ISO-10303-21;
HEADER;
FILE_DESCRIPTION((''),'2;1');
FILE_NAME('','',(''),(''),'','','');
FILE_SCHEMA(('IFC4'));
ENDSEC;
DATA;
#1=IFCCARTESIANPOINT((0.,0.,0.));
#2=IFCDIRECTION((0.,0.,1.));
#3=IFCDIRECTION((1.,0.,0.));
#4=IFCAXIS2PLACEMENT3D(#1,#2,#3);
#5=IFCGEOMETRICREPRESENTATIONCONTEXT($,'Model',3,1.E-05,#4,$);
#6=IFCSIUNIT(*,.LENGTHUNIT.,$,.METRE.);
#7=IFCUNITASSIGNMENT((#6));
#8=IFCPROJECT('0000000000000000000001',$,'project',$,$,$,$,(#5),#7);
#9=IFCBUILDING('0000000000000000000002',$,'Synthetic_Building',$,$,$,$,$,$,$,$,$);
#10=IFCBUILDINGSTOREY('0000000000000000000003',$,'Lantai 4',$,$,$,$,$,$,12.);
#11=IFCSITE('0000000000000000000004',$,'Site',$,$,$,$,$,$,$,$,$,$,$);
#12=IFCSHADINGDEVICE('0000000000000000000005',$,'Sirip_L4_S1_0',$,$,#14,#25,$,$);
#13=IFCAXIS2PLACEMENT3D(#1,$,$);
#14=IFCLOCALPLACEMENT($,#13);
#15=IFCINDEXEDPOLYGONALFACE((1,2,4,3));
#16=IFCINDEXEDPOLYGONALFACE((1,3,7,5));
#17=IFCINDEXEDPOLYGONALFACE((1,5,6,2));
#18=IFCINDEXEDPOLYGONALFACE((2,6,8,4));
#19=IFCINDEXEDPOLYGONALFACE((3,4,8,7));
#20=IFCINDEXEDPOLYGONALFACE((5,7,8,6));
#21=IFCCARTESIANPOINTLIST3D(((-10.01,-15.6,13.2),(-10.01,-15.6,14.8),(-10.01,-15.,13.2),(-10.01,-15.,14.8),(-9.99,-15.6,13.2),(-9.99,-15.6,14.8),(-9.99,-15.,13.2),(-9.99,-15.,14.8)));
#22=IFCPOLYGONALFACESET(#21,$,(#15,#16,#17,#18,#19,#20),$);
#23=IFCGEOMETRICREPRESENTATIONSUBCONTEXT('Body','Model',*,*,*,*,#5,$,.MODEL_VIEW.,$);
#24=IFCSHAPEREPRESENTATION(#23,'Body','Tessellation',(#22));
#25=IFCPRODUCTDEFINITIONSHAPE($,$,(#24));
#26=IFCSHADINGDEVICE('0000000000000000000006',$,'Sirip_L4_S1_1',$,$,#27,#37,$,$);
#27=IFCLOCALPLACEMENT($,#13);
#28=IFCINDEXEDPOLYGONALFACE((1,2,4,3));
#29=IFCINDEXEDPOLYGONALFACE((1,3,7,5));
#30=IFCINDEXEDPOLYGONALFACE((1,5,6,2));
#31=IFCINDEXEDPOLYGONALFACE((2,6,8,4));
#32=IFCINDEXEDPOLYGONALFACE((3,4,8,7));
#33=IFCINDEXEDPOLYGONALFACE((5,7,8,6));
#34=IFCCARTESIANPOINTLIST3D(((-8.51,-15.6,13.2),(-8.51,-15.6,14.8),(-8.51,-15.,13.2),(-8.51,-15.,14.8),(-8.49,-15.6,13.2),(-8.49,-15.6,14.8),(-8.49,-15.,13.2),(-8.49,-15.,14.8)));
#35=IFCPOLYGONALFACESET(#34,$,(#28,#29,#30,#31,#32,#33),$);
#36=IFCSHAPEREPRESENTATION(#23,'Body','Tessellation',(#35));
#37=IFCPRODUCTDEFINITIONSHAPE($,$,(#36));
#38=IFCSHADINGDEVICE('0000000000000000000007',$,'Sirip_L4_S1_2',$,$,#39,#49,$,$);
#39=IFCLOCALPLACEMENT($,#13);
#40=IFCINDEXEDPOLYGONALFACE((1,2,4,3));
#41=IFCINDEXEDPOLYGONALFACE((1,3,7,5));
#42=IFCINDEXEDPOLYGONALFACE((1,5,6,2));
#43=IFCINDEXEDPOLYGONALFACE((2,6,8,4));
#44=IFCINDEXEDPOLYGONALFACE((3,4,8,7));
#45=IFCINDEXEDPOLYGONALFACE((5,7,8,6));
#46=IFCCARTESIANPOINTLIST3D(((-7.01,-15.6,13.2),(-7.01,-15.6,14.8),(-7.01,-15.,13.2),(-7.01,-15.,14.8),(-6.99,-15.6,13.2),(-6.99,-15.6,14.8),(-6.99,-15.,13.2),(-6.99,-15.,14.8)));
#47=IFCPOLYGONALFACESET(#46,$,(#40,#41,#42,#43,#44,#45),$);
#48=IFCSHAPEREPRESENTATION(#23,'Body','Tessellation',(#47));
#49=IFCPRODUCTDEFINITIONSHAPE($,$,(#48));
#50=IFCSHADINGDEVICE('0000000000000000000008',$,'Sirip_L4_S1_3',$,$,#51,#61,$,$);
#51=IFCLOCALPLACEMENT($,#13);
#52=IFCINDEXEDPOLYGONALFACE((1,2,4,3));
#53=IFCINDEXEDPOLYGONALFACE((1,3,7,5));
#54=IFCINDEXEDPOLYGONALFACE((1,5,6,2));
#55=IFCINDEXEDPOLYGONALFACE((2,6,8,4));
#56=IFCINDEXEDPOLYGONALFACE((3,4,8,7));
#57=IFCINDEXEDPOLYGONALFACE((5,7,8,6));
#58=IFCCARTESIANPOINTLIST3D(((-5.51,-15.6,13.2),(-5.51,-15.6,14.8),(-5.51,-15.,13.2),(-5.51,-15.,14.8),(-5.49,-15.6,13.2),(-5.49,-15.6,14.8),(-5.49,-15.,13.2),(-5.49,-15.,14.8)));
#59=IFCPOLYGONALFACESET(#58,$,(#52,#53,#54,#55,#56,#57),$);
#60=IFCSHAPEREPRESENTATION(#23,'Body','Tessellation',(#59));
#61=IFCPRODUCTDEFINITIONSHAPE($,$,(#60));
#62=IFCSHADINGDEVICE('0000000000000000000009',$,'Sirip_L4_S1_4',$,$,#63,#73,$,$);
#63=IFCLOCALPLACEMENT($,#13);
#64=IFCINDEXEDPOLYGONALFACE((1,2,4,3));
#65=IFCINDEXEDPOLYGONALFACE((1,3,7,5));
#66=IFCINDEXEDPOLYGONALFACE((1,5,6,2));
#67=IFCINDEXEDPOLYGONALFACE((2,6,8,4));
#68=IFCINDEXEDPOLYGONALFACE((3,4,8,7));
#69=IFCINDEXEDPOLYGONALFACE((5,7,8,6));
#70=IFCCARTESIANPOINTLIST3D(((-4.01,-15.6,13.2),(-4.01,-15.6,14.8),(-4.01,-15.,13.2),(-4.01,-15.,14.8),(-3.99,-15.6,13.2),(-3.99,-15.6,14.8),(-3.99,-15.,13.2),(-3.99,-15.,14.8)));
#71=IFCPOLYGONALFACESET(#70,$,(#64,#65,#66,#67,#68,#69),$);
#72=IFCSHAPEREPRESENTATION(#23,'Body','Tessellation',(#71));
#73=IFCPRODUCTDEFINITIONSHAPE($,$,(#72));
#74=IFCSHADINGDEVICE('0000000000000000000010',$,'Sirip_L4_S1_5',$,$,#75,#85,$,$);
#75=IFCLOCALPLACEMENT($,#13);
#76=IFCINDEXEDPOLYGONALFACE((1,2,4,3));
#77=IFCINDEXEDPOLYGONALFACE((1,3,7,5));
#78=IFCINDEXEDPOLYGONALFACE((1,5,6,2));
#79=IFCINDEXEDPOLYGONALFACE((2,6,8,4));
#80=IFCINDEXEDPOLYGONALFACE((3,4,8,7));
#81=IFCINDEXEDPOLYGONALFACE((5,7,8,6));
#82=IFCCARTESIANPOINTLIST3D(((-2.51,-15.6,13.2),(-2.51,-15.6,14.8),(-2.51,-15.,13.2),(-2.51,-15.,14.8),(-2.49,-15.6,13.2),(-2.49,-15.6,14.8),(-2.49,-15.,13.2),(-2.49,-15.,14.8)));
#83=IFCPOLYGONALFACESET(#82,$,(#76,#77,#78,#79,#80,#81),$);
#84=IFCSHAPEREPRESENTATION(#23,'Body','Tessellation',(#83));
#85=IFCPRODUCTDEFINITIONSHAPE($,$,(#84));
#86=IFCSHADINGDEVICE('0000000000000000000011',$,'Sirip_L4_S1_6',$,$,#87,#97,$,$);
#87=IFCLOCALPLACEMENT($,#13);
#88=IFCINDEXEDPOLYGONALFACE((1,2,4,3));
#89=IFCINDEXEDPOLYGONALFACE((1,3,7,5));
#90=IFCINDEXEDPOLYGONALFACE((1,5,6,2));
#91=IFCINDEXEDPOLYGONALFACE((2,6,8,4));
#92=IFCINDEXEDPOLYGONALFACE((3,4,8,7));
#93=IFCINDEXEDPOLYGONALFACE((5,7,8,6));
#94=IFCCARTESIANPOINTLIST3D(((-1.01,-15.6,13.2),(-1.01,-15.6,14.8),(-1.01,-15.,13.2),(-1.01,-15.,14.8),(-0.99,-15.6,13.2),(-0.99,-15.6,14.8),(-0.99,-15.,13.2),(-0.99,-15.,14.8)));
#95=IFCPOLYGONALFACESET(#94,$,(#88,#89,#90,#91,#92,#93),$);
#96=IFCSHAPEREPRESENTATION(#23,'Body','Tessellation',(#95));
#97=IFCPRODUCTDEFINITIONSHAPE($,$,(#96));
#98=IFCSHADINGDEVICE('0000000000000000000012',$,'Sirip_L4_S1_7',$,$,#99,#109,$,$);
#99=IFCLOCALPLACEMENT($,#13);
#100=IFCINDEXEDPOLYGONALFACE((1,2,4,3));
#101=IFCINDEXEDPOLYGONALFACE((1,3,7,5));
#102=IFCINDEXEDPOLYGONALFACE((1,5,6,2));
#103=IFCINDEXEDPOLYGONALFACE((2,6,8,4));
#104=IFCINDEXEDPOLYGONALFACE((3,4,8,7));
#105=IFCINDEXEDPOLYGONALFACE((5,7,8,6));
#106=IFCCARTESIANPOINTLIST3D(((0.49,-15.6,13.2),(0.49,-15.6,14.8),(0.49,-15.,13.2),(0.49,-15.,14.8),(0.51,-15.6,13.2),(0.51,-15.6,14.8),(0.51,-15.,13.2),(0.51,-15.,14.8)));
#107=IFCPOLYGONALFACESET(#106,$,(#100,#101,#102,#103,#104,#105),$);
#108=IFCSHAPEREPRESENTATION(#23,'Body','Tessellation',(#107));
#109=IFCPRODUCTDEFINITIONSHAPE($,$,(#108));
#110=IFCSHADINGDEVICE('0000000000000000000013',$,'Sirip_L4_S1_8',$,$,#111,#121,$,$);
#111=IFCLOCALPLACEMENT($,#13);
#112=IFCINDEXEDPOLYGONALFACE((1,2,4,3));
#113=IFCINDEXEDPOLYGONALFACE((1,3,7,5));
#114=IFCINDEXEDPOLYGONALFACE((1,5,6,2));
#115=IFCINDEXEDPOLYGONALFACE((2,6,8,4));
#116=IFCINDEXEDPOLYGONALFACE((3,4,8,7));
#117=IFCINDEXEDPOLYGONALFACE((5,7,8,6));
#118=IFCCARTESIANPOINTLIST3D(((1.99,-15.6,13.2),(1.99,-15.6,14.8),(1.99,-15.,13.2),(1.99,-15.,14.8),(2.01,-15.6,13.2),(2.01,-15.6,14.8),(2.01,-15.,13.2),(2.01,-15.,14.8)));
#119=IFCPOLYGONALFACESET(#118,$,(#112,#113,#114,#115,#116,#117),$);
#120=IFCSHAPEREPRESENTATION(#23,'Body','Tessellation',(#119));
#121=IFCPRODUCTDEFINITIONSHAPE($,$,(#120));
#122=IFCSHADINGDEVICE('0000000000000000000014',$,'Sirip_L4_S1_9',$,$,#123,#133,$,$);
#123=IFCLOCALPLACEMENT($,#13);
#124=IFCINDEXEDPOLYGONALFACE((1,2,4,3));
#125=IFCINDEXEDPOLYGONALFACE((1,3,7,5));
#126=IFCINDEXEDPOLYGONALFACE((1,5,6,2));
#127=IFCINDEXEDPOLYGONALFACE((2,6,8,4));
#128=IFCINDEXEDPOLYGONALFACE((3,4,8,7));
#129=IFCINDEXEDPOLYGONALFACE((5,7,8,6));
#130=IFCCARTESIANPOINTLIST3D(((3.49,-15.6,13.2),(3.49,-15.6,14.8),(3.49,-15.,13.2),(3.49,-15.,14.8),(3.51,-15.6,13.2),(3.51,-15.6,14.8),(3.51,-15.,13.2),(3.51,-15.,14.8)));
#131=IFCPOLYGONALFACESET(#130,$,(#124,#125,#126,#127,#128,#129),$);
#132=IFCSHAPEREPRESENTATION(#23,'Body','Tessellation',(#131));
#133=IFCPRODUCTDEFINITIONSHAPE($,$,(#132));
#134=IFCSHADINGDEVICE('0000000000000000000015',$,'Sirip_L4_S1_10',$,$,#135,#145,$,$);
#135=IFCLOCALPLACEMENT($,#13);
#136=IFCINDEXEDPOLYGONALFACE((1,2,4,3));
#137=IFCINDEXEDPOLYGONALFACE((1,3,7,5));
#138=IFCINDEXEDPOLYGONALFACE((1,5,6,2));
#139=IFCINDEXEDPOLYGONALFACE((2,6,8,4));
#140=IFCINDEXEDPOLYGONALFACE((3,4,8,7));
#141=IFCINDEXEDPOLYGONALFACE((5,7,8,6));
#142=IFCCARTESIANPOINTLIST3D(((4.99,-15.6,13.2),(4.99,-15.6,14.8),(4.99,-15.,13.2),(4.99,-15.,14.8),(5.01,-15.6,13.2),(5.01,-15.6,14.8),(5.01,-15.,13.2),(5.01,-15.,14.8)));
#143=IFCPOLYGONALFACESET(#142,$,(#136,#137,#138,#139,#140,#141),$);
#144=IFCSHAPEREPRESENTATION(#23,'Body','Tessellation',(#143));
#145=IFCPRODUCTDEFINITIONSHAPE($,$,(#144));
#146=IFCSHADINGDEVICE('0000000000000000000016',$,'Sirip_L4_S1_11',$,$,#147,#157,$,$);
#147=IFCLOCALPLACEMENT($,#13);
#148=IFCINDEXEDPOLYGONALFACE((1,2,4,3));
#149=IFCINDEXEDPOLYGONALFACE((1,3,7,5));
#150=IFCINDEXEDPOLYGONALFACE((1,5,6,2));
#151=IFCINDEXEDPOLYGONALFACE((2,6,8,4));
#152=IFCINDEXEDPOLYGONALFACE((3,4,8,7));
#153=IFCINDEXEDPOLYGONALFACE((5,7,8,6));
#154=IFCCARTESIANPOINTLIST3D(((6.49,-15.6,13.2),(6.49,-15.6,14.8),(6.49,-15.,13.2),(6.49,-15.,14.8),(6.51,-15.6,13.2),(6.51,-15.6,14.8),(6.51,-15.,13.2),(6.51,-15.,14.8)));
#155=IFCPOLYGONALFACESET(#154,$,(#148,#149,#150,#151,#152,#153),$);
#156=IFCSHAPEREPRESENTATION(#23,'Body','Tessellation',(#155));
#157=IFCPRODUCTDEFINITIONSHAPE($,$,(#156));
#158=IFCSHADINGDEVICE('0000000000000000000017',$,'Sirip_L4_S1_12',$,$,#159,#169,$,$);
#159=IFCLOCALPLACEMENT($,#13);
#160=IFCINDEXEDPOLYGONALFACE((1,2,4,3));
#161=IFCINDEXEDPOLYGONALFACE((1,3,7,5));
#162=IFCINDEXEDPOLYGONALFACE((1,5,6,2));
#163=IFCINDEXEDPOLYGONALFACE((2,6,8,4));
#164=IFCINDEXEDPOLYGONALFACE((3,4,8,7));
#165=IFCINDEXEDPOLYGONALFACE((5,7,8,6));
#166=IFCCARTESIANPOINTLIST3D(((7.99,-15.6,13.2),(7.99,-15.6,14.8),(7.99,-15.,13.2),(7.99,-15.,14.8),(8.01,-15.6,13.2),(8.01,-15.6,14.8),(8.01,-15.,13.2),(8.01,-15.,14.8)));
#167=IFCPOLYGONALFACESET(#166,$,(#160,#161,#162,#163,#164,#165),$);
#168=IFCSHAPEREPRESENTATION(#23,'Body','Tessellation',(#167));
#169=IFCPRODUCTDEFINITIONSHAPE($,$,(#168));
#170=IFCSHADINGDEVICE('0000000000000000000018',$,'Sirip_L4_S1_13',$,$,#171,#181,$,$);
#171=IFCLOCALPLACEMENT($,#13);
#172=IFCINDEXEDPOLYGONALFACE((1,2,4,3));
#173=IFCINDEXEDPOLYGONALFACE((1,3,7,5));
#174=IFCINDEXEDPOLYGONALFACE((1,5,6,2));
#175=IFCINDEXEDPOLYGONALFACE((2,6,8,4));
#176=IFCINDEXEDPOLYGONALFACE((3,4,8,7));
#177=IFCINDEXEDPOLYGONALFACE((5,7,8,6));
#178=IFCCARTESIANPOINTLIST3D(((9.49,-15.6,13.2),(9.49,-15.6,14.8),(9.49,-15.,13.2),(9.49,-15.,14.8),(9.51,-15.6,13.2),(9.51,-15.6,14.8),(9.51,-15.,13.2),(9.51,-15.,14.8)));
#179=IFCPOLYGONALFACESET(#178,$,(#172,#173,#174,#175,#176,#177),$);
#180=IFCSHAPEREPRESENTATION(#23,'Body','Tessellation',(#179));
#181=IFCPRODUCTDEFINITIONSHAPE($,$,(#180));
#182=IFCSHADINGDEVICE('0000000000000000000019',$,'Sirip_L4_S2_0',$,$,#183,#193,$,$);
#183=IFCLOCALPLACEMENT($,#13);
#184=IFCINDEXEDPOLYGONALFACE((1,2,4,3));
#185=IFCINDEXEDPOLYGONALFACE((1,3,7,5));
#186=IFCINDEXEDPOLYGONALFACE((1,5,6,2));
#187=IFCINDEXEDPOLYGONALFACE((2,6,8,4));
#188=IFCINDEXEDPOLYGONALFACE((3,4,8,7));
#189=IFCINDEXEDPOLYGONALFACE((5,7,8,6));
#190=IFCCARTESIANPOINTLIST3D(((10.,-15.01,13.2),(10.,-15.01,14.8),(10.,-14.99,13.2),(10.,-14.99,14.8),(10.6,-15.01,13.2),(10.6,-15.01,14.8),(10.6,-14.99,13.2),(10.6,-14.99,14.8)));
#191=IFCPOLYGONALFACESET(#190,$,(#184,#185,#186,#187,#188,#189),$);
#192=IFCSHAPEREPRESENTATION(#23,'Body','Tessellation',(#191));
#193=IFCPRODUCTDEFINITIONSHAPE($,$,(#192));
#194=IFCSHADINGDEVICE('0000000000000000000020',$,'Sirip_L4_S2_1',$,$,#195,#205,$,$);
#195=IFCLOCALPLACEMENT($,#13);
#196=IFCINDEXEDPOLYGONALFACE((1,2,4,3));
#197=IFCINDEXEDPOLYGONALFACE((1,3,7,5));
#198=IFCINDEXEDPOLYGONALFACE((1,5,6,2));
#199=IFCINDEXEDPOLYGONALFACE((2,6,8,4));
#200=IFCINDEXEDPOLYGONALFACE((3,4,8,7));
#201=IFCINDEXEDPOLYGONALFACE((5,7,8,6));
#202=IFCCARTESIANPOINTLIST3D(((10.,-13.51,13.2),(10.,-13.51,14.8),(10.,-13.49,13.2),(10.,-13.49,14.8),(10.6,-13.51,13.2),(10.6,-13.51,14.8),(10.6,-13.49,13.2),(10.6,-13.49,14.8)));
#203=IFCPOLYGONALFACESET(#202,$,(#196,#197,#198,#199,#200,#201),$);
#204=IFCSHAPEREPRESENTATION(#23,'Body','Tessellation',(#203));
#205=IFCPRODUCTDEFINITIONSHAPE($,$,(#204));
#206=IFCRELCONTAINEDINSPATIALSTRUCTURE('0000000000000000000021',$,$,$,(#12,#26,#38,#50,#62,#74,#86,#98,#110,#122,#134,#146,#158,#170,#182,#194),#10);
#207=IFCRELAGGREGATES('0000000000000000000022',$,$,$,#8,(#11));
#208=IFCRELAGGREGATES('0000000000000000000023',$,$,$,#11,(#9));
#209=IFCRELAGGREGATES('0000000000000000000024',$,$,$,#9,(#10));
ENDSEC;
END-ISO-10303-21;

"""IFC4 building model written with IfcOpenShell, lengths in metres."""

from ifc_helpers import new_model, si_unit, frame, origin_with_axes, place, context, subcontext, project, spatial, polyline, outline, extrude, element, save


model = new_model("IFC4")

# Units and contexts
model_context = context("Model", 3, precision=1e-05, world=origin_with_axes())
body_context = subcontext(model_context, "Body", "Model", "MODEL_VIEW")
ifc_project = project(units=[si_unit("LENGTHUNIT", "METRE")], contexts=[model_context])

# Site, building, storey
site = spatial("IfcSite", under=ifc_project, Name="Site")
building = spatial("IfcBuilding", under=site, Name="Synthetic_Building")
storey = spatial("IfcBuildingStorey", under=building, Name="Lantai 4", Elevation=12.0)

# Shading devices
shading_device_1_placement = place(None, origin_with_axes())
element("IfcShadingDevice", 1, at=shading_device_1_placement, inside=storey, Name="Sirip_L4_S1_0", context=body_context, shape_type="SweptSolid", body=[
    extrude(outline(polyline([(-10.01, -15.0), (-9.99, -15.0), (-9.99, -15.6), (-10.01, -15.6), (-10.01, -15.0)])), frame((0.0, 0.0, 13.2), z_axis=(0.0, 0.0, 1.0), x_axis=(1.0, 0.0, 0.0)), (0.0, 0.0, 1.0), 1.6),
])
shading_device_2_placement = place(None, origin_with_axes())
element("IfcShadingDevice", 2, at=shading_device_2_placement, inside=storey, Name="Sirip_L4_S1_1", context=body_context, shape_type="SweptSolid", body=[
    extrude(outline(polyline([(-8.51, -15.0), (-8.49, -15.0), (-8.49, -15.6), (-8.51, -15.6), (-8.51, -15.0)])), frame((0.0, 0.0, 13.2), z_axis=(0.0, 0.0, 1.0), x_axis=(1.0, 0.0, 0.0)), (0.0, 0.0, 1.0), 1.6),
])
shading_device_3_placement = place(None, origin_with_axes())
element("IfcShadingDevice", 3, at=shading_device_3_placement, inside=storey, Name="Sirip_L4_S1_2", context=body_context, shape_type="SweptSolid", body=[
    extrude(outline(polyline([(-7.01, -15.0), (-6.99, -15.0), (-6.99, -15.6), (-7.01, -15.6), (-7.01, -15.0)])), frame((0.0, 0.0, 13.2), z_axis=(0.0, 0.0, 1.0), x_axis=(1.0, 0.0, 0.0)), (0.0, 0.0, 1.0), 1.6),
])
shading_device_4_placement = place(None, origin_with_axes())
element("IfcShadingDevice", 4, at=shading_device_4_placement, inside=storey, Name="Sirip_L4_S1_3", context=body_context, shape_type="SweptSolid", body=[
    extrude(outline(polyline([(-5.51, -15.0), (-5.49, -15.0), (-5.49, -15.6), (-5.51, -15.6), (-5.51, -15.0)])), frame((0.0, 0.0, 13.2), z_axis=(0.0, 0.0, 1.0), x_axis=(1.0, 0.0, 0.0)), (0.0, 0.0, 1.0), 1.6),
])
shading_device_5_placement = place(None, origin_with_axes())
element("IfcShadingDevice", 5, at=shading_device_5_placement, inside=storey, Name="Sirip_L4_S1_4", context=body_context, shape_type="SweptSolid", body=[
    extrude(outline(polyline([(-4.01, -15.0), (-3.99, -15.0), (-3.99, -15.6), (-4.01, -15.6), (-4.01, -15.0)])), frame((0.0, 0.0, 13.2), z_axis=(0.0, 0.0, 1.0), x_axis=(1.0, 0.0, 0.0)), (0.0, 0.0, 1.0), 1.6),
])
shading_device_6_placement = place(None, origin_with_axes())
element("IfcShadingDevice", 6, at=shading_device_6_placement, inside=storey, Name="Sirip_L4_S1_5", context=body_context, shape_type="SweptSolid", body=[
    extrude(outline(polyline([(-2.51, -15.0), (-2.49, -15.0), (-2.49, -15.6), (-2.51, -15.6), (-2.51, -15.0)])), frame((0.0, 0.0, 13.2), z_axis=(0.0, 0.0, 1.0), x_axis=(1.0, 0.0, 0.0)), (0.0, 0.0, 1.0), 1.6),
])
shading_device_7_placement = place(None, origin_with_axes())
element("IfcShadingDevice", 7, at=shading_device_7_placement, inside=storey, Name="Sirip_L4_S1_6", context=body_context, shape_type="SweptSolid", body=[
    extrude(outline(polyline([(-1.01, -15.0), (-0.99, -15.0), (-0.99, -15.6), (-1.01, -15.6), (-1.01, -15.0)])), frame((0.0, 0.0, 13.2), z_axis=(0.0, 0.0, 1.0), x_axis=(1.0, 0.0, 0.0)), (0.0, 0.0, 1.0), 1.6),
])
shading_device_8_placement = place(None, origin_with_axes())
element("IfcShadingDevice", 8, at=shading_device_8_placement, inside=storey, Name="Sirip_L4_S1_7", context=body_context, shape_type="SweptSolid", body=[
    extrude(outline(polyline([(0.49, -15.0), (0.51, -15.0), (0.51, -15.6), (0.49, -15.6), (0.49, -15.0)])), frame((0.0, 0.0, 13.2), z_axis=(0.0, 0.0, 1.0), x_axis=(1.0, 0.0, 0.0)), (0.0, 0.0, 1.0), 1.6),
])
shading_device_9_placement = place(None, origin_with_axes())
element("IfcShadingDevice", 9, at=shading_device_9_placement, inside=storey, Name="Sirip_L4_S1_8", context=body_context, shape_type="SweptSolid", body=[
    extrude(outline(polyline([(1.99, -15.0), (2.01, -15.0), (2.01, -15.6), (1.99, -15.6), (1.99, -15.0)])), frame((0.0, 0.0, 13.2), z_axis=(0.0, 0.0, 1.0), x_axis=(1.0, 0.0, 0.0)), (0.0, 0.0, 1.0), 1.6),
])
shading_device_10_placement = place(None, origin_with_axes())
element("IfcShadingDevice", 10, at=shading_device_10_placement, inside=storey, Name="Sirip_L4_S1_9", context=body_context, shape_type="SweptSolid", body=[
    extrude(outline(polyline([(3.49, -15.0), (3.51, -15.0), (3.51, -15.6), (3.49, -15.6), (3.49, -15.0)])), frame((0.0, 0.0, 13.2), z_axis=(0.0, 0.0, 1.0), x_axis=(1.0, 0.0, 0.0)), (0.0, 0.0, 1.0), 1.6),
])
shading_device_11_placement = place(None, origin_with_axes())
element("IfcShadingDevice", 11, at=shading_device_11_placement, inside=storey, Name="Sirip_L4_S1_10", context=body_context, shape_type="SweptSolid", body=[
    extrude(outline(polyline([(4.99, -15.0), (5.01, -15.0), (5.01, -15.6), (4.99, -15.6), (4.99, -15.0)])), frame((0.0, 0.0, 13.2), z_axis=(0.0, 0.0, 1.0), x_axis=(1.0, 0.0, 0.0)), (0.0, 0.0, 1.0), 1.6),
])
shading_device_12_placement = place(None, origin_with_axes())
element("IfcShadingDevice", 12, at=shading_device_12_placement, inside=storey, Name="Sirip_L4_S1_11", context=body_context, shape_type="SweptSolid", body=[
    extrude(outline(polyline([(6.49, -15.0), (6.51, -15.0), (6.51, -15.6), (6.49, -15.6), (6.49, -15.0)])), frame((0.0, 0.0, 13.2), z_axis=(0.0, 0.0, 1.0), x_axis=(1.0, 0.0, 0.0)), (0.0, 0.0, 1.0), 1.6),
])
shading_device_13_placement = place(None, origin_with_axes())
element("IfcShadingDevice", 13, at=shading_device_13_placement, inside=storey, Name="Sirip_L4_S1_12", context=body_context, shape_type="SweptSolid", body=[
    extrude(outline(polyline([(7.99, -15.0), (8.01, -15.0), (8.01, -15.6), (7.99, -15.6), (7.99, -15.0)])), frame((0.0, 0.0, 13.2), z_axis=(0.0, 0.0, 1.0), x_axis=(1.0, 0.0, 0.0)), (0.0, 0.0, 1.0), 1.6),
])
shading_device_14_placement = place(None, origin_with_axes())
element("IfcShadingDevice", 14, at=shading_device_14_placement, inside=storey, Name="Sirip_L4_S1_13", context=body_context, shape_type="SweptSolid", body=[
    extrude(outline(polyline([(9.49, -15.0), (9.51, -15.0), (9.51, -15.6), (9.49, -15.6), (9.49, -15.0)])), frame((0.0, 0.0, 13.2), z_axis=(0.0, 0.0, 1.0), x_axis=(1.0, 0.0, 0.0)), (0.0, 0.0, 1.0), 1.6),
])
shading_device_15_placement = place(None, origin_with_axes())
element("IfcShadingDevice", 15, at=shading_device_15_placement, inside=storey, Name="Sirip_L4_S2_0", context=body_context, shape_type="SweptSolid", body=[
    extrude(outline(polyline([(10.0, -15.01), (10.0, -14.99), (10.6, -14.99), (10.6, -15.01), (10.0, -15.01)])), frame((0.0, 0.0, 13.2), z_axis=(0.0, 0.0, 1.0), x_axis=(1.0, 0.0, 0.0)), (0.0, 0.0, 1.0), 1.6),
])
shading_device_16_placement = place(None, origin_with_axes())
element("IfcShadingDevice", 16, at=shading_device_16_placement, inside=storey, Name="Sirip_L4_S2_1", context=body_context, shape_type="SweptSolid", body=[
    extrude(outline(polyline([(10.0, -13.51), (10.0, -13.49), (10.6, -13.49), (10.6, -13.51), (10.0, -13.51)])), frame((0.0, 0.0, 13.2), z_axis=(0.0, 0.0, 1.0), x_axis=(1.0, 0.0, 0.0)), (0.0, 0.0, 1.0), 1.6),
])

save(model, "model.ifc")
